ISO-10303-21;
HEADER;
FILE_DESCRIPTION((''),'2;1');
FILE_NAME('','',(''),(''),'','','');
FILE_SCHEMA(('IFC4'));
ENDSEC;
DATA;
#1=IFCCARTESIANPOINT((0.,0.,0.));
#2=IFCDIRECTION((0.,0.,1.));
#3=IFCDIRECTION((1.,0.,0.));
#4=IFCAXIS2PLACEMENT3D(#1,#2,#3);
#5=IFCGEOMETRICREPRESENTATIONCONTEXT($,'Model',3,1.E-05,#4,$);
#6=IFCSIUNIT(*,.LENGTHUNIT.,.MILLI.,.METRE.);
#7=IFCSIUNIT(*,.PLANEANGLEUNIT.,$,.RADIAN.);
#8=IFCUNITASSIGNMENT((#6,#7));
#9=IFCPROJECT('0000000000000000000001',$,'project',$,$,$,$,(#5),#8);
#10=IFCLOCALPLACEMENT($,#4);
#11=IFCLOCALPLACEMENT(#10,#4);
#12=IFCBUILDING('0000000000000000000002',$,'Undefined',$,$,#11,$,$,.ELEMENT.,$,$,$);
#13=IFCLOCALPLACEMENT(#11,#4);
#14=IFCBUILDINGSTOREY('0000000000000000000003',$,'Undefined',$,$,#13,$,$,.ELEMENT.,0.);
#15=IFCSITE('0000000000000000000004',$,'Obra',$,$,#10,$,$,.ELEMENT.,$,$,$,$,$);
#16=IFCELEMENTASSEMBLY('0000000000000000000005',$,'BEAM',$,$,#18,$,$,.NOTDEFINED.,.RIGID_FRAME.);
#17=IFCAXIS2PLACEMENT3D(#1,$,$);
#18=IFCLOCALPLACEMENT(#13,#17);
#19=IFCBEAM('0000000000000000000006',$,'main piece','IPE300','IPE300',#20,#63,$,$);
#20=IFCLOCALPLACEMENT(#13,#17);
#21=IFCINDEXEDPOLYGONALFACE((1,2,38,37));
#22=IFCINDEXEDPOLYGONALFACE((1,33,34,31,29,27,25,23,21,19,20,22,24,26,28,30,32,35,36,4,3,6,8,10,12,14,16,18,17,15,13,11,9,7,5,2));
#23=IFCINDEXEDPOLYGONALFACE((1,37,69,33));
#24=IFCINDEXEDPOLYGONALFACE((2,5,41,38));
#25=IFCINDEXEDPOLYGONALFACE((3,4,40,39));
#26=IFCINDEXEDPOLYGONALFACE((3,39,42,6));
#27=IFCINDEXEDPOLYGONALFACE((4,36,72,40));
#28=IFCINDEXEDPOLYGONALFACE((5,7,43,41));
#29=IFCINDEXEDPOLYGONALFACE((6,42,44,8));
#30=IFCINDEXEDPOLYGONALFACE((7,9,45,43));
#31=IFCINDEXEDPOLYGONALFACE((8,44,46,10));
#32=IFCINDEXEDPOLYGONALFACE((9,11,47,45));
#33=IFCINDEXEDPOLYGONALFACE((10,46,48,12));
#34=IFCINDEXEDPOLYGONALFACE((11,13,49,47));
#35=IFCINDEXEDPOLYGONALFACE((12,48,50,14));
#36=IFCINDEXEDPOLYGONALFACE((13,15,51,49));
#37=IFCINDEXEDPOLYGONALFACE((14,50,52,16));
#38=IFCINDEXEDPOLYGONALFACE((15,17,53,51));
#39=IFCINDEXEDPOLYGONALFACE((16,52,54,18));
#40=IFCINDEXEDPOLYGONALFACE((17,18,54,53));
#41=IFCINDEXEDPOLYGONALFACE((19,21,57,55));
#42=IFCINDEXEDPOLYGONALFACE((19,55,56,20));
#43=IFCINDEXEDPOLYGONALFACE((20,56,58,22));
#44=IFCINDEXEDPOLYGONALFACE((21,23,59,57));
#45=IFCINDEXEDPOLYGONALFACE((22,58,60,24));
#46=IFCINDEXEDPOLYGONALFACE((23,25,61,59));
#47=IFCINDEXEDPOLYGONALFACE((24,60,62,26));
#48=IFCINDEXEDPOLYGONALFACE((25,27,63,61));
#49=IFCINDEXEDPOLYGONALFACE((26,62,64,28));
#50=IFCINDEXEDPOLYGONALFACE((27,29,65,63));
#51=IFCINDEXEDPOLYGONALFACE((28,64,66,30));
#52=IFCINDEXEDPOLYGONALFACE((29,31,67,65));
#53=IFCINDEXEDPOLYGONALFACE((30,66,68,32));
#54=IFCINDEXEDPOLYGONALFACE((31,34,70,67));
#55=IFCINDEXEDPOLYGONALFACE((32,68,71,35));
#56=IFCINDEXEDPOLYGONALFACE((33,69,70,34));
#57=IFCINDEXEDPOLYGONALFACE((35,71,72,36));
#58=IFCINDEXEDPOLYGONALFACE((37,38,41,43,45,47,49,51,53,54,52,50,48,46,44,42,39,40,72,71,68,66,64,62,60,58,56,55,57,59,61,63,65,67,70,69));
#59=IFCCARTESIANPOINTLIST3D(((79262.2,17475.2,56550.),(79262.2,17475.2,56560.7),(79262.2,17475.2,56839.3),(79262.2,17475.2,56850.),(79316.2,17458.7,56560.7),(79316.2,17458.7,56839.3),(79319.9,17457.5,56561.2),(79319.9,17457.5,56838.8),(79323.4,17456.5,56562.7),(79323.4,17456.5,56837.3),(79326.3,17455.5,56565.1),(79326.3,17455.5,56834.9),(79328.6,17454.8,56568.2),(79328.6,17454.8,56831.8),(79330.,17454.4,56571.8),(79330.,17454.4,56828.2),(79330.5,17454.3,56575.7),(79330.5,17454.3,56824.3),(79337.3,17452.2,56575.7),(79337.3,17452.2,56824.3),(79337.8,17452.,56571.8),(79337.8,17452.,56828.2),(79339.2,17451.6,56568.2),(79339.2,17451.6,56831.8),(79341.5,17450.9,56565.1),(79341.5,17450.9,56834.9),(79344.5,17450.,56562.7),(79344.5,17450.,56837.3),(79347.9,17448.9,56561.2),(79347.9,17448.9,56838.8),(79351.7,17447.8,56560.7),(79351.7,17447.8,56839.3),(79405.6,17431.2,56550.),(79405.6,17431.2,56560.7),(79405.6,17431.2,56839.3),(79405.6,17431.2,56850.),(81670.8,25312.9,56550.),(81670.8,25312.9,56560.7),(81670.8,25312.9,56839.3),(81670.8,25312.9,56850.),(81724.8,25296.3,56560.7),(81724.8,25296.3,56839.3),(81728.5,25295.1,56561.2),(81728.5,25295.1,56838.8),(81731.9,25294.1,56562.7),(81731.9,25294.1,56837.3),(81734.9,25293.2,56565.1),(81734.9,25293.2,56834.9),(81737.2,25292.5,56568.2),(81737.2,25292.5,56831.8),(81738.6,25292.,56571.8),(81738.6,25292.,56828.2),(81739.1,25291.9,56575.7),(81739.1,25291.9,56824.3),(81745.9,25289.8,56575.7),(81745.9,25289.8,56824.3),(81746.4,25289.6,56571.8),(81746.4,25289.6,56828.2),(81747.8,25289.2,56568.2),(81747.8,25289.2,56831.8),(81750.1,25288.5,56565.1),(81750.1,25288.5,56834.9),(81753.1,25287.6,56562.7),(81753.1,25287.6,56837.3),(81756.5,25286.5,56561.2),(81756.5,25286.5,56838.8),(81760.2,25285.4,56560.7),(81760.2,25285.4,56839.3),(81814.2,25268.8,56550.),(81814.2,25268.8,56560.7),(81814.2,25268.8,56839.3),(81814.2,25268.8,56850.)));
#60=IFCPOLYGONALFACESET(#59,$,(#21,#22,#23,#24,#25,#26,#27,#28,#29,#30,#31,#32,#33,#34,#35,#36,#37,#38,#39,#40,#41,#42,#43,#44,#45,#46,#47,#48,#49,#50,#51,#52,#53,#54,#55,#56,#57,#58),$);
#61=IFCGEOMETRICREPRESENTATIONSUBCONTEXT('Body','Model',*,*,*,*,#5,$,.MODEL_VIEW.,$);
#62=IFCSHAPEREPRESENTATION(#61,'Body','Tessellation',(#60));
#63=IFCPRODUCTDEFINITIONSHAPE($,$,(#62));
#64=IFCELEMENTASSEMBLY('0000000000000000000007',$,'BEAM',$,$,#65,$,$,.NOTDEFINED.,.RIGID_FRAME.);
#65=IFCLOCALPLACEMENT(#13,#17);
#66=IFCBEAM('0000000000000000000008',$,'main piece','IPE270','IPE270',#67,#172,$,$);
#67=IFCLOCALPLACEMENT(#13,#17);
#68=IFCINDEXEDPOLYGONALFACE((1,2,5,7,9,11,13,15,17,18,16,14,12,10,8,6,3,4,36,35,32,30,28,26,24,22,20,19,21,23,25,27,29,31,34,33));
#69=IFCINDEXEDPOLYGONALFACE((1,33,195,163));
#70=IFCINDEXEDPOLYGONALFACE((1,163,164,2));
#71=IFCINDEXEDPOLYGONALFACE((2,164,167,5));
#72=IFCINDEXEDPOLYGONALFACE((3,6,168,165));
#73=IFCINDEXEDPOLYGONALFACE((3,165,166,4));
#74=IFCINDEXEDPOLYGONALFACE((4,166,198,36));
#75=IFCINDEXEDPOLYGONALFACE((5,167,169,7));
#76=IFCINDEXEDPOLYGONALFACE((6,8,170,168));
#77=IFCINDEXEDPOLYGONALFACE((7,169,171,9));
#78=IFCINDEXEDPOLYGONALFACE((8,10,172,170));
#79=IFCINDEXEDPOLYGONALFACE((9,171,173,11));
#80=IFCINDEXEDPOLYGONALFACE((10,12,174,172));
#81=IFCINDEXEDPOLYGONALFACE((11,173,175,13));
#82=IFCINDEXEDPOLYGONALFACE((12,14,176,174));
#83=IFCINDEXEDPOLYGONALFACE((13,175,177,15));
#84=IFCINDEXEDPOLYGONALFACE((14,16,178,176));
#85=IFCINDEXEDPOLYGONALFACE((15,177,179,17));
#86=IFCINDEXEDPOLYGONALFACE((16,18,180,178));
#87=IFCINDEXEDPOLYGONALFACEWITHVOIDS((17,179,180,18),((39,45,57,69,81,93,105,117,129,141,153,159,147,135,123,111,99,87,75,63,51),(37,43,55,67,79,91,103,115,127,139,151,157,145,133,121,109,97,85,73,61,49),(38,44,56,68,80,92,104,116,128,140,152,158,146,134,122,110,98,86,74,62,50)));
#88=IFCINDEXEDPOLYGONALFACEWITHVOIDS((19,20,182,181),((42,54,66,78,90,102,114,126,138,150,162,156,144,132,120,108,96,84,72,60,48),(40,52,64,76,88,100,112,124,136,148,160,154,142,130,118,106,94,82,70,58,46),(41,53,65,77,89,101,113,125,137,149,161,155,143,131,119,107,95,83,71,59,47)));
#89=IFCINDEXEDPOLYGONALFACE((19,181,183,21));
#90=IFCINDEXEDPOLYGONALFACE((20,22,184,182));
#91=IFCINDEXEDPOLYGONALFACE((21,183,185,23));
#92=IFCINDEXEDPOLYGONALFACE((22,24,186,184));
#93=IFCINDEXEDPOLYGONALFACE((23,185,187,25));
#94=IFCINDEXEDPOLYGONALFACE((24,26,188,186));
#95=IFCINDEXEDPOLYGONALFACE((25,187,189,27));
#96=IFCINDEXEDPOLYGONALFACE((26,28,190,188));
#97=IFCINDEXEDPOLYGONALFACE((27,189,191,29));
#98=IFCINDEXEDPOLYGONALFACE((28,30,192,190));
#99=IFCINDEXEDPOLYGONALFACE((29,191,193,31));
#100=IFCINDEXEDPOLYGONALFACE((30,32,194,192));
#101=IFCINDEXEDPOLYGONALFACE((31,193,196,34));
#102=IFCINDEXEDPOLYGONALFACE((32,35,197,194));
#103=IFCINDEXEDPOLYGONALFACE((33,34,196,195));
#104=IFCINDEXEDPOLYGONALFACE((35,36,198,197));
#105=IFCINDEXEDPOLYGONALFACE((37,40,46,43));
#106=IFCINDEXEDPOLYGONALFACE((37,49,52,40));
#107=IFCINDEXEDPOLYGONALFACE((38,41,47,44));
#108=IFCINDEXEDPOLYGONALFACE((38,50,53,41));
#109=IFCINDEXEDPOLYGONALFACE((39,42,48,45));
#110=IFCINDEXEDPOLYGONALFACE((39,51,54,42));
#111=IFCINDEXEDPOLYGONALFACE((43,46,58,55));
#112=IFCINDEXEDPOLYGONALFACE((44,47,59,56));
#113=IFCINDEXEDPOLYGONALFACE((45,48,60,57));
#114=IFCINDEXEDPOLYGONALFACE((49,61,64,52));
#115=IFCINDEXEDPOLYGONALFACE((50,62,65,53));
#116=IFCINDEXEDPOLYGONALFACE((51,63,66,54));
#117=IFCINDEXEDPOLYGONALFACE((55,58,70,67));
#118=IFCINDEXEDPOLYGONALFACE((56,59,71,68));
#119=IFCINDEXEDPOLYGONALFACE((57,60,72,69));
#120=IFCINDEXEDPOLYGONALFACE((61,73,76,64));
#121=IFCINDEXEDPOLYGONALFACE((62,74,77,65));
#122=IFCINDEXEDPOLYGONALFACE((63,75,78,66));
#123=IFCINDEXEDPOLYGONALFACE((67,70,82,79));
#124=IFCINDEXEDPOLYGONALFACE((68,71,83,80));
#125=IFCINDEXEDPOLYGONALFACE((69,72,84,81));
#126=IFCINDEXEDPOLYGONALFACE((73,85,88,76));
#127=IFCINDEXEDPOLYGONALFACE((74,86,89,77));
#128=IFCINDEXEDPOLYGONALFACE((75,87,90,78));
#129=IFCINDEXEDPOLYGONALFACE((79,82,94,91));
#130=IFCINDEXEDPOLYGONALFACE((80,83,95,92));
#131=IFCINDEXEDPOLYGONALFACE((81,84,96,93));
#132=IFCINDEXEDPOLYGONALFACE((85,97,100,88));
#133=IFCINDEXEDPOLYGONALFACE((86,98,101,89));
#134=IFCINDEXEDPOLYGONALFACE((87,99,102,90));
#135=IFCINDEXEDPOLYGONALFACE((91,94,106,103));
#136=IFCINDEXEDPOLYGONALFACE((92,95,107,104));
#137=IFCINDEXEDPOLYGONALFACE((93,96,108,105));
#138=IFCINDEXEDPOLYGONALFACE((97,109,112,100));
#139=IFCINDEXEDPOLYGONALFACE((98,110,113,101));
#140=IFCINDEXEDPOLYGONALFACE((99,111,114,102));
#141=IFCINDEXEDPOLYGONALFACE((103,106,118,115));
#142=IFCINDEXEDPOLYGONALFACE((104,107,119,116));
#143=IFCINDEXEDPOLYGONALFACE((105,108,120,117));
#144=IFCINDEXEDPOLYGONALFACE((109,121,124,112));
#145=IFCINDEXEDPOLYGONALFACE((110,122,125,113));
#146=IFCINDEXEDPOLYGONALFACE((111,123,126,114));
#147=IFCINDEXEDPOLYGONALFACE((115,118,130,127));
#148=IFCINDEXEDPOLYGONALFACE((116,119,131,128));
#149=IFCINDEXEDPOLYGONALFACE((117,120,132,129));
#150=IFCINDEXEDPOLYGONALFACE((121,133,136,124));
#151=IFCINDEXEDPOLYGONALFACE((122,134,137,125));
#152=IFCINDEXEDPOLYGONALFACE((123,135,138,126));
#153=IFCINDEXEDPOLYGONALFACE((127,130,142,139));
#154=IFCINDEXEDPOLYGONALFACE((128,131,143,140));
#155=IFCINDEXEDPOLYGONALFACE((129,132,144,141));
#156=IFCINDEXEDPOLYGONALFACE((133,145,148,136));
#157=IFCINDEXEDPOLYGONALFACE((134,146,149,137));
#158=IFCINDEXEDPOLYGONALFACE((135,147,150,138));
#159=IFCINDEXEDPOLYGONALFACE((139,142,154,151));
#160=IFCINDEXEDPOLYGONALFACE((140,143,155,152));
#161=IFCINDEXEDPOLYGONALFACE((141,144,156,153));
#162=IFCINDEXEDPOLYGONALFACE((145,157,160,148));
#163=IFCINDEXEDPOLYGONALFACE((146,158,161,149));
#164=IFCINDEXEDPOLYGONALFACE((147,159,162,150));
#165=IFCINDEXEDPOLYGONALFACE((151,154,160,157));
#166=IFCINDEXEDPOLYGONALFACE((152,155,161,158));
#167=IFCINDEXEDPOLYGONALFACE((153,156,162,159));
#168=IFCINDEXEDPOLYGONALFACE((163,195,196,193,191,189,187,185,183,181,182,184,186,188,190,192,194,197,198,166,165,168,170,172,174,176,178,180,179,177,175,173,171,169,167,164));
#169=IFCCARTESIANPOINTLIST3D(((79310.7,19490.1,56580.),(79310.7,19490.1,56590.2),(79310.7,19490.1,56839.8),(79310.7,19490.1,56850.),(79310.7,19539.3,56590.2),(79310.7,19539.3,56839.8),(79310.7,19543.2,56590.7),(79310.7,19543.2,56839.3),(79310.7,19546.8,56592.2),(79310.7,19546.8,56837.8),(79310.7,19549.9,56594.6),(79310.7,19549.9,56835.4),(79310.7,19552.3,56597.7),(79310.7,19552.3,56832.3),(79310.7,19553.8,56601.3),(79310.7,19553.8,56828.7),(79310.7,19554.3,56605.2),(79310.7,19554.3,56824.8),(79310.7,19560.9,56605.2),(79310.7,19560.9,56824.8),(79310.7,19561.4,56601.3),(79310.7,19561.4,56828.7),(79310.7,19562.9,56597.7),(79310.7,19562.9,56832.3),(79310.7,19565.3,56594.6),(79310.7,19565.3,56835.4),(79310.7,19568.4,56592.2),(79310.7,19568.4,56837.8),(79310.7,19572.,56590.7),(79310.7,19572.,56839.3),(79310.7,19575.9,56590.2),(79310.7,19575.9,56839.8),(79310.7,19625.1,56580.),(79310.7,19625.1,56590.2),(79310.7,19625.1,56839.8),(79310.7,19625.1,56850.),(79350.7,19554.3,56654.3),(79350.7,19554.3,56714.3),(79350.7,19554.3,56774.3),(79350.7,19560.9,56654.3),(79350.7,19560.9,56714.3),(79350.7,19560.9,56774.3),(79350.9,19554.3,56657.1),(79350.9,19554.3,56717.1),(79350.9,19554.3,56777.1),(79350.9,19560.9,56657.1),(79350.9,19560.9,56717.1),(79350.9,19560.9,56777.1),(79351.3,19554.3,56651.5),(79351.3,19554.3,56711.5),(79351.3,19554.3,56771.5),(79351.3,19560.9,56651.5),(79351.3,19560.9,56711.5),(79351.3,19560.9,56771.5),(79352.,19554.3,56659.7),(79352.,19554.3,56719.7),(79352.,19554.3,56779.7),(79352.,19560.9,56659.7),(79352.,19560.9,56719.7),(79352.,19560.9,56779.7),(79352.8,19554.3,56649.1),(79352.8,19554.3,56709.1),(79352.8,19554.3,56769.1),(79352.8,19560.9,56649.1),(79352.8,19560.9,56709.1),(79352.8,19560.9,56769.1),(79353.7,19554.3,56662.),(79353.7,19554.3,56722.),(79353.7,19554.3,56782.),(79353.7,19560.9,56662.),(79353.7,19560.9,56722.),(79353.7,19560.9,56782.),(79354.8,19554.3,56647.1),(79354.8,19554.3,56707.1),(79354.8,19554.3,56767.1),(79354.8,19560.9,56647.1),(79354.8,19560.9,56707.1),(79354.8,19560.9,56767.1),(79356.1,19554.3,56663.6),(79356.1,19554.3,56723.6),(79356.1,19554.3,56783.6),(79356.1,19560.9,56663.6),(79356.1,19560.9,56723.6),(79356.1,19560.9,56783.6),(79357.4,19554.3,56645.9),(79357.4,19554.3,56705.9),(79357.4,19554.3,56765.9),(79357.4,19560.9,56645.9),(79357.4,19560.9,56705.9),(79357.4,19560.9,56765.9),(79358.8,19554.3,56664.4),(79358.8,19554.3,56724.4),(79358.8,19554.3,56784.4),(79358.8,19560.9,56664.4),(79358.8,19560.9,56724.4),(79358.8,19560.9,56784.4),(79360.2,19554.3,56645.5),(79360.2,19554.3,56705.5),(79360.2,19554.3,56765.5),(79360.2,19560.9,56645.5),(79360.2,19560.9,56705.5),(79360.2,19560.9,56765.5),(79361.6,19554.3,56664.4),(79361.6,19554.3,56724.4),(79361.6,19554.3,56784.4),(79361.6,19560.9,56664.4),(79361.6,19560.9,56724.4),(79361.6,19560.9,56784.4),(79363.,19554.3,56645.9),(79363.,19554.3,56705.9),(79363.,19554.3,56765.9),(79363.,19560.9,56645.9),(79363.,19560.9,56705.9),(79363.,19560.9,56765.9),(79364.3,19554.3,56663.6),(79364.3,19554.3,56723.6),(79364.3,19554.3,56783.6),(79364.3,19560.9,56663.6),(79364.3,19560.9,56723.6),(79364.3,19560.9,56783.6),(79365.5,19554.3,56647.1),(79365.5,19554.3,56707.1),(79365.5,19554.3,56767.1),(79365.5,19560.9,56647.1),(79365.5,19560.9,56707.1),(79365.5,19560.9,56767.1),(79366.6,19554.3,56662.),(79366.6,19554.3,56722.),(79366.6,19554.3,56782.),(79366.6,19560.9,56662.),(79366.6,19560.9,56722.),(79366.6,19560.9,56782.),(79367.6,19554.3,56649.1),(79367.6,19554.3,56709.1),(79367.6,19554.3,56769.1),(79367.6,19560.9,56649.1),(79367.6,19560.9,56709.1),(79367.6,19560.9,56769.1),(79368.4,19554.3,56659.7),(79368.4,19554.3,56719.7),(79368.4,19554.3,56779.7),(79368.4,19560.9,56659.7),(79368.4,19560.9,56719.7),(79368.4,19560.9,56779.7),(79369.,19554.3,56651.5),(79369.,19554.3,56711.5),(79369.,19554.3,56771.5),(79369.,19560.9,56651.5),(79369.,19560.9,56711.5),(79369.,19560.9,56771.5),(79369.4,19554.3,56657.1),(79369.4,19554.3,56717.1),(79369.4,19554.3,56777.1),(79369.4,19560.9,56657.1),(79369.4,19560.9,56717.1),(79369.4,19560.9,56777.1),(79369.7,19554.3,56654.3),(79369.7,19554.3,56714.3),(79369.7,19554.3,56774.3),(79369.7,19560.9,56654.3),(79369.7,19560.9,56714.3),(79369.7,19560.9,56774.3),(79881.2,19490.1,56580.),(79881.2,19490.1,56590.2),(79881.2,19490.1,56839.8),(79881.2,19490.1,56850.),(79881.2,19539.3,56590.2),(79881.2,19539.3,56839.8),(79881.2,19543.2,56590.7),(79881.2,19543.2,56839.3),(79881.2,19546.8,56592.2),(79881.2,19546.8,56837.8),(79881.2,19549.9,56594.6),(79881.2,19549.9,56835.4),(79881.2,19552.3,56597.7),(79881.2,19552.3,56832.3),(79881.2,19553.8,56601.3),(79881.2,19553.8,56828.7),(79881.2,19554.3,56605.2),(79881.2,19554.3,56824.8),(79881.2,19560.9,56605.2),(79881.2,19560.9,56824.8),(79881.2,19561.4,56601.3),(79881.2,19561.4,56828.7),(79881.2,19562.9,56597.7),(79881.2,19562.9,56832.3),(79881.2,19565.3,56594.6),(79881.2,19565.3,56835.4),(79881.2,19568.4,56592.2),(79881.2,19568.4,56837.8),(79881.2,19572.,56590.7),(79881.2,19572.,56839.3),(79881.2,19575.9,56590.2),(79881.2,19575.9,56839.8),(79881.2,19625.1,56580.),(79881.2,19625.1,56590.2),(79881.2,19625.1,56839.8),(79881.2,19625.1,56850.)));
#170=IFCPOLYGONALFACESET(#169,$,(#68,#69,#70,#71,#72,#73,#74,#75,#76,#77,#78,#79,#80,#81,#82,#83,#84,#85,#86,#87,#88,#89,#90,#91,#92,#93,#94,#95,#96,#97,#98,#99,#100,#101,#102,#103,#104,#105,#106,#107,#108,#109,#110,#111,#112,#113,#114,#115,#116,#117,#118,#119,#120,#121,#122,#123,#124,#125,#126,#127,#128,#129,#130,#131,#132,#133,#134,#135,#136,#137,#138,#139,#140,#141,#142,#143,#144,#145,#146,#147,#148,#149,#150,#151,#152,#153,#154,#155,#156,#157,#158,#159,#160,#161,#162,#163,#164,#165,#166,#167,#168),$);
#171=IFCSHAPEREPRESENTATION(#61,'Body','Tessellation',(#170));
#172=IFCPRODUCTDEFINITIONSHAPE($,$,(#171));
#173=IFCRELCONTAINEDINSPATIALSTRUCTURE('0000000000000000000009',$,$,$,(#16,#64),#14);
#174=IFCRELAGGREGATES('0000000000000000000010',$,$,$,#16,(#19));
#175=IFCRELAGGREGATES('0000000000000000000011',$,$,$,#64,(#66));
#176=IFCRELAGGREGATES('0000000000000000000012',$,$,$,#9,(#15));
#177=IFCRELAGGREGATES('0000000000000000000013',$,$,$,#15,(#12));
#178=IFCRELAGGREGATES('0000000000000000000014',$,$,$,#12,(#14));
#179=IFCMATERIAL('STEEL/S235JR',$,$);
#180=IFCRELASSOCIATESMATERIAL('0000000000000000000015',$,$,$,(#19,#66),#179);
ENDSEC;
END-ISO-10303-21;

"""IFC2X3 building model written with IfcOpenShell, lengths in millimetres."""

from ifc_helpers import new_model, si_unit, frame, origin_with_axes, origin_2d_with_axis, place, context, subcontext, project, spatial, circle, i_section, extrude, clip, halfspace, source, transform, mapped, material, element, aggregate, save


model = new_model("IFC2X3")

# Units and contexts
model_context = context("Model", 3, precision=1e-05, world=origin_with_axes())
body_context = subcontext(model_context, "Body", "Model", "MODEL_VIEW")
ifc_project = project(units=[si_unit("LENGTHUNIT", "METRE", prefix="MILLI"), si_unit("PLANEANGLEUNIT", "RADIAN")], contexts=[model_context])

# Site, building, storey
site_placement = place(None, origin_with_axes())
site = spatial("IfcSite", under=ifc_project, at=site_placement, Name="Obra", CompositionType="ELEMENT")
building_placement = place(site_placement, origin_with_axes())
building = spatial("IfcBuilding", under=site, at=building_placement, Name="Undefined", CompositionType="ELEMENT")
storey_placement = place(building_placement, origin_with_axes())
storey = spatial("IfcBuildingStorey", under=building, at=storey_placement, Name="Undefined", CompositionType="ELEMENT", Elevation=0.0)

# Element assembly, beam
ifc_material = material(Name="STEEL/S235JR")
assembly_1_placement = place(storey_placement, origin_with_axes())
assembly_1 = element("IfcElementAssembly", 1, at=assembly_1_placement, inside=storey, Name="BEAM", AssemblyPlace="NOTDEFINED", PredefinedType="RIGID_FRAME")
beam_1_placement = place(assembly_1_placement, frame((79333.9, 17453.2, 56700.0), z_axis=(0.0, 0.0, 1.0), x_axis=(0.293752, 0.955882, 0.0)))
beam_1 = element("IfcBeam", 2, at=beam_1_placement, material=ifc_material, Name="main piece", Description="IPE300", ObjectType="IPE300", context=body_context, shape_type="SweptSolid", body=[
    extrude(i_section(OverallWidth=150.0, OverallDepth=300.0, WebThickness=7.1, FlangeThickness=10.7, FilletRadius=15.0, at=origin_2d_with_axis()), frame((8199.4, 0.0, 0.0), z_axis=(-1.0, 0.0, 0.0), x_axis=(0.0, -1.0, 0.0)), (0.0, 0.0, 1.0), 8199.4),
])
aggregate(assembly_1, [beam_1])

# Element assembly, beam, opening
assembly_2_placement = place(storey_placement, origin_with_axes())
assembly_2 = element("IfcElementAssembly", 3, at=assembly_2_placement, inside=storey, Name="BEAM", AssemblyPlace="NOTDEFINED", PredefinedType="RIGID_FRAME")
beam_2_placement = place(assembly_2_placement, frame((78913.0, 19557.6, 56715.0), z_axis=(0.0, 0.0, 1.0), x_axis=(1.0, 0.0, 0.0)))
beam_2 = element("IfcBeam", 4, at=beam_2_placement, material=ifc_material, Name="main piece", Description="IPE270", ObjectType="IPE270", context=body_context, shape_type="Clipping", body=[
    clip(extrude(i_section(OverallWidth=135.0, OverallDepth=270.0, WebThickness=6.6, FlangeThickness=10.2, FilletRadius=15.0, at=origin_2d_with_axis()), frame((968.2, 0.0, 0.0), z_axis=(-1.0, 0.0, 0.0), x_axis=(0.0, -1.0, 0.0)), (0.0, 0.0, 1.0), 968.2), halfspace(frame((397.6, 60.0, -120.0), z_axis=(-1.0, -0.000019, 0.0), x_axis=(0.0, 0.0, 1.0)), False)),
])
shared_shape_1 = source(origin_with_axes(), body_context, "Body", "SweptSolid", [
    extrude(circle(Radius=9.5, at=origin_2d_with_axis()), frame((0.0, -3.4, 0.0), z_axis=(0.0, 1.0, 0.0), x_axis=(1.0, 0.0, 0.0)), (0.0, 0.0, 1.0), 6.8),
])
opening_1_placement = place(assembly_2_placement, frame((79310.2, 19557.6, 56835.0), z_axis=(1.0, 0.0, 0.0), x_axis=(0.0, 0.0, -1.0)))
element("IfcOpeningElement", 5, at=opening_1_placement, cuts=beam_2, ObjectType="Opening", context=body_context, shape_type="MappedRepresentation", body=[
    mapped(shared_shape_1, transform((60.0, 0.0, 50.0))),
    mapped(shared_shape_1, transform((120.0, 0.0, 50.0))),
    mapped(shared_shape_1, transform((180.0, 0.0, 50.0))),
])
aggregate(assembly_2, [beam_2])

save(model, "model.ifc")
